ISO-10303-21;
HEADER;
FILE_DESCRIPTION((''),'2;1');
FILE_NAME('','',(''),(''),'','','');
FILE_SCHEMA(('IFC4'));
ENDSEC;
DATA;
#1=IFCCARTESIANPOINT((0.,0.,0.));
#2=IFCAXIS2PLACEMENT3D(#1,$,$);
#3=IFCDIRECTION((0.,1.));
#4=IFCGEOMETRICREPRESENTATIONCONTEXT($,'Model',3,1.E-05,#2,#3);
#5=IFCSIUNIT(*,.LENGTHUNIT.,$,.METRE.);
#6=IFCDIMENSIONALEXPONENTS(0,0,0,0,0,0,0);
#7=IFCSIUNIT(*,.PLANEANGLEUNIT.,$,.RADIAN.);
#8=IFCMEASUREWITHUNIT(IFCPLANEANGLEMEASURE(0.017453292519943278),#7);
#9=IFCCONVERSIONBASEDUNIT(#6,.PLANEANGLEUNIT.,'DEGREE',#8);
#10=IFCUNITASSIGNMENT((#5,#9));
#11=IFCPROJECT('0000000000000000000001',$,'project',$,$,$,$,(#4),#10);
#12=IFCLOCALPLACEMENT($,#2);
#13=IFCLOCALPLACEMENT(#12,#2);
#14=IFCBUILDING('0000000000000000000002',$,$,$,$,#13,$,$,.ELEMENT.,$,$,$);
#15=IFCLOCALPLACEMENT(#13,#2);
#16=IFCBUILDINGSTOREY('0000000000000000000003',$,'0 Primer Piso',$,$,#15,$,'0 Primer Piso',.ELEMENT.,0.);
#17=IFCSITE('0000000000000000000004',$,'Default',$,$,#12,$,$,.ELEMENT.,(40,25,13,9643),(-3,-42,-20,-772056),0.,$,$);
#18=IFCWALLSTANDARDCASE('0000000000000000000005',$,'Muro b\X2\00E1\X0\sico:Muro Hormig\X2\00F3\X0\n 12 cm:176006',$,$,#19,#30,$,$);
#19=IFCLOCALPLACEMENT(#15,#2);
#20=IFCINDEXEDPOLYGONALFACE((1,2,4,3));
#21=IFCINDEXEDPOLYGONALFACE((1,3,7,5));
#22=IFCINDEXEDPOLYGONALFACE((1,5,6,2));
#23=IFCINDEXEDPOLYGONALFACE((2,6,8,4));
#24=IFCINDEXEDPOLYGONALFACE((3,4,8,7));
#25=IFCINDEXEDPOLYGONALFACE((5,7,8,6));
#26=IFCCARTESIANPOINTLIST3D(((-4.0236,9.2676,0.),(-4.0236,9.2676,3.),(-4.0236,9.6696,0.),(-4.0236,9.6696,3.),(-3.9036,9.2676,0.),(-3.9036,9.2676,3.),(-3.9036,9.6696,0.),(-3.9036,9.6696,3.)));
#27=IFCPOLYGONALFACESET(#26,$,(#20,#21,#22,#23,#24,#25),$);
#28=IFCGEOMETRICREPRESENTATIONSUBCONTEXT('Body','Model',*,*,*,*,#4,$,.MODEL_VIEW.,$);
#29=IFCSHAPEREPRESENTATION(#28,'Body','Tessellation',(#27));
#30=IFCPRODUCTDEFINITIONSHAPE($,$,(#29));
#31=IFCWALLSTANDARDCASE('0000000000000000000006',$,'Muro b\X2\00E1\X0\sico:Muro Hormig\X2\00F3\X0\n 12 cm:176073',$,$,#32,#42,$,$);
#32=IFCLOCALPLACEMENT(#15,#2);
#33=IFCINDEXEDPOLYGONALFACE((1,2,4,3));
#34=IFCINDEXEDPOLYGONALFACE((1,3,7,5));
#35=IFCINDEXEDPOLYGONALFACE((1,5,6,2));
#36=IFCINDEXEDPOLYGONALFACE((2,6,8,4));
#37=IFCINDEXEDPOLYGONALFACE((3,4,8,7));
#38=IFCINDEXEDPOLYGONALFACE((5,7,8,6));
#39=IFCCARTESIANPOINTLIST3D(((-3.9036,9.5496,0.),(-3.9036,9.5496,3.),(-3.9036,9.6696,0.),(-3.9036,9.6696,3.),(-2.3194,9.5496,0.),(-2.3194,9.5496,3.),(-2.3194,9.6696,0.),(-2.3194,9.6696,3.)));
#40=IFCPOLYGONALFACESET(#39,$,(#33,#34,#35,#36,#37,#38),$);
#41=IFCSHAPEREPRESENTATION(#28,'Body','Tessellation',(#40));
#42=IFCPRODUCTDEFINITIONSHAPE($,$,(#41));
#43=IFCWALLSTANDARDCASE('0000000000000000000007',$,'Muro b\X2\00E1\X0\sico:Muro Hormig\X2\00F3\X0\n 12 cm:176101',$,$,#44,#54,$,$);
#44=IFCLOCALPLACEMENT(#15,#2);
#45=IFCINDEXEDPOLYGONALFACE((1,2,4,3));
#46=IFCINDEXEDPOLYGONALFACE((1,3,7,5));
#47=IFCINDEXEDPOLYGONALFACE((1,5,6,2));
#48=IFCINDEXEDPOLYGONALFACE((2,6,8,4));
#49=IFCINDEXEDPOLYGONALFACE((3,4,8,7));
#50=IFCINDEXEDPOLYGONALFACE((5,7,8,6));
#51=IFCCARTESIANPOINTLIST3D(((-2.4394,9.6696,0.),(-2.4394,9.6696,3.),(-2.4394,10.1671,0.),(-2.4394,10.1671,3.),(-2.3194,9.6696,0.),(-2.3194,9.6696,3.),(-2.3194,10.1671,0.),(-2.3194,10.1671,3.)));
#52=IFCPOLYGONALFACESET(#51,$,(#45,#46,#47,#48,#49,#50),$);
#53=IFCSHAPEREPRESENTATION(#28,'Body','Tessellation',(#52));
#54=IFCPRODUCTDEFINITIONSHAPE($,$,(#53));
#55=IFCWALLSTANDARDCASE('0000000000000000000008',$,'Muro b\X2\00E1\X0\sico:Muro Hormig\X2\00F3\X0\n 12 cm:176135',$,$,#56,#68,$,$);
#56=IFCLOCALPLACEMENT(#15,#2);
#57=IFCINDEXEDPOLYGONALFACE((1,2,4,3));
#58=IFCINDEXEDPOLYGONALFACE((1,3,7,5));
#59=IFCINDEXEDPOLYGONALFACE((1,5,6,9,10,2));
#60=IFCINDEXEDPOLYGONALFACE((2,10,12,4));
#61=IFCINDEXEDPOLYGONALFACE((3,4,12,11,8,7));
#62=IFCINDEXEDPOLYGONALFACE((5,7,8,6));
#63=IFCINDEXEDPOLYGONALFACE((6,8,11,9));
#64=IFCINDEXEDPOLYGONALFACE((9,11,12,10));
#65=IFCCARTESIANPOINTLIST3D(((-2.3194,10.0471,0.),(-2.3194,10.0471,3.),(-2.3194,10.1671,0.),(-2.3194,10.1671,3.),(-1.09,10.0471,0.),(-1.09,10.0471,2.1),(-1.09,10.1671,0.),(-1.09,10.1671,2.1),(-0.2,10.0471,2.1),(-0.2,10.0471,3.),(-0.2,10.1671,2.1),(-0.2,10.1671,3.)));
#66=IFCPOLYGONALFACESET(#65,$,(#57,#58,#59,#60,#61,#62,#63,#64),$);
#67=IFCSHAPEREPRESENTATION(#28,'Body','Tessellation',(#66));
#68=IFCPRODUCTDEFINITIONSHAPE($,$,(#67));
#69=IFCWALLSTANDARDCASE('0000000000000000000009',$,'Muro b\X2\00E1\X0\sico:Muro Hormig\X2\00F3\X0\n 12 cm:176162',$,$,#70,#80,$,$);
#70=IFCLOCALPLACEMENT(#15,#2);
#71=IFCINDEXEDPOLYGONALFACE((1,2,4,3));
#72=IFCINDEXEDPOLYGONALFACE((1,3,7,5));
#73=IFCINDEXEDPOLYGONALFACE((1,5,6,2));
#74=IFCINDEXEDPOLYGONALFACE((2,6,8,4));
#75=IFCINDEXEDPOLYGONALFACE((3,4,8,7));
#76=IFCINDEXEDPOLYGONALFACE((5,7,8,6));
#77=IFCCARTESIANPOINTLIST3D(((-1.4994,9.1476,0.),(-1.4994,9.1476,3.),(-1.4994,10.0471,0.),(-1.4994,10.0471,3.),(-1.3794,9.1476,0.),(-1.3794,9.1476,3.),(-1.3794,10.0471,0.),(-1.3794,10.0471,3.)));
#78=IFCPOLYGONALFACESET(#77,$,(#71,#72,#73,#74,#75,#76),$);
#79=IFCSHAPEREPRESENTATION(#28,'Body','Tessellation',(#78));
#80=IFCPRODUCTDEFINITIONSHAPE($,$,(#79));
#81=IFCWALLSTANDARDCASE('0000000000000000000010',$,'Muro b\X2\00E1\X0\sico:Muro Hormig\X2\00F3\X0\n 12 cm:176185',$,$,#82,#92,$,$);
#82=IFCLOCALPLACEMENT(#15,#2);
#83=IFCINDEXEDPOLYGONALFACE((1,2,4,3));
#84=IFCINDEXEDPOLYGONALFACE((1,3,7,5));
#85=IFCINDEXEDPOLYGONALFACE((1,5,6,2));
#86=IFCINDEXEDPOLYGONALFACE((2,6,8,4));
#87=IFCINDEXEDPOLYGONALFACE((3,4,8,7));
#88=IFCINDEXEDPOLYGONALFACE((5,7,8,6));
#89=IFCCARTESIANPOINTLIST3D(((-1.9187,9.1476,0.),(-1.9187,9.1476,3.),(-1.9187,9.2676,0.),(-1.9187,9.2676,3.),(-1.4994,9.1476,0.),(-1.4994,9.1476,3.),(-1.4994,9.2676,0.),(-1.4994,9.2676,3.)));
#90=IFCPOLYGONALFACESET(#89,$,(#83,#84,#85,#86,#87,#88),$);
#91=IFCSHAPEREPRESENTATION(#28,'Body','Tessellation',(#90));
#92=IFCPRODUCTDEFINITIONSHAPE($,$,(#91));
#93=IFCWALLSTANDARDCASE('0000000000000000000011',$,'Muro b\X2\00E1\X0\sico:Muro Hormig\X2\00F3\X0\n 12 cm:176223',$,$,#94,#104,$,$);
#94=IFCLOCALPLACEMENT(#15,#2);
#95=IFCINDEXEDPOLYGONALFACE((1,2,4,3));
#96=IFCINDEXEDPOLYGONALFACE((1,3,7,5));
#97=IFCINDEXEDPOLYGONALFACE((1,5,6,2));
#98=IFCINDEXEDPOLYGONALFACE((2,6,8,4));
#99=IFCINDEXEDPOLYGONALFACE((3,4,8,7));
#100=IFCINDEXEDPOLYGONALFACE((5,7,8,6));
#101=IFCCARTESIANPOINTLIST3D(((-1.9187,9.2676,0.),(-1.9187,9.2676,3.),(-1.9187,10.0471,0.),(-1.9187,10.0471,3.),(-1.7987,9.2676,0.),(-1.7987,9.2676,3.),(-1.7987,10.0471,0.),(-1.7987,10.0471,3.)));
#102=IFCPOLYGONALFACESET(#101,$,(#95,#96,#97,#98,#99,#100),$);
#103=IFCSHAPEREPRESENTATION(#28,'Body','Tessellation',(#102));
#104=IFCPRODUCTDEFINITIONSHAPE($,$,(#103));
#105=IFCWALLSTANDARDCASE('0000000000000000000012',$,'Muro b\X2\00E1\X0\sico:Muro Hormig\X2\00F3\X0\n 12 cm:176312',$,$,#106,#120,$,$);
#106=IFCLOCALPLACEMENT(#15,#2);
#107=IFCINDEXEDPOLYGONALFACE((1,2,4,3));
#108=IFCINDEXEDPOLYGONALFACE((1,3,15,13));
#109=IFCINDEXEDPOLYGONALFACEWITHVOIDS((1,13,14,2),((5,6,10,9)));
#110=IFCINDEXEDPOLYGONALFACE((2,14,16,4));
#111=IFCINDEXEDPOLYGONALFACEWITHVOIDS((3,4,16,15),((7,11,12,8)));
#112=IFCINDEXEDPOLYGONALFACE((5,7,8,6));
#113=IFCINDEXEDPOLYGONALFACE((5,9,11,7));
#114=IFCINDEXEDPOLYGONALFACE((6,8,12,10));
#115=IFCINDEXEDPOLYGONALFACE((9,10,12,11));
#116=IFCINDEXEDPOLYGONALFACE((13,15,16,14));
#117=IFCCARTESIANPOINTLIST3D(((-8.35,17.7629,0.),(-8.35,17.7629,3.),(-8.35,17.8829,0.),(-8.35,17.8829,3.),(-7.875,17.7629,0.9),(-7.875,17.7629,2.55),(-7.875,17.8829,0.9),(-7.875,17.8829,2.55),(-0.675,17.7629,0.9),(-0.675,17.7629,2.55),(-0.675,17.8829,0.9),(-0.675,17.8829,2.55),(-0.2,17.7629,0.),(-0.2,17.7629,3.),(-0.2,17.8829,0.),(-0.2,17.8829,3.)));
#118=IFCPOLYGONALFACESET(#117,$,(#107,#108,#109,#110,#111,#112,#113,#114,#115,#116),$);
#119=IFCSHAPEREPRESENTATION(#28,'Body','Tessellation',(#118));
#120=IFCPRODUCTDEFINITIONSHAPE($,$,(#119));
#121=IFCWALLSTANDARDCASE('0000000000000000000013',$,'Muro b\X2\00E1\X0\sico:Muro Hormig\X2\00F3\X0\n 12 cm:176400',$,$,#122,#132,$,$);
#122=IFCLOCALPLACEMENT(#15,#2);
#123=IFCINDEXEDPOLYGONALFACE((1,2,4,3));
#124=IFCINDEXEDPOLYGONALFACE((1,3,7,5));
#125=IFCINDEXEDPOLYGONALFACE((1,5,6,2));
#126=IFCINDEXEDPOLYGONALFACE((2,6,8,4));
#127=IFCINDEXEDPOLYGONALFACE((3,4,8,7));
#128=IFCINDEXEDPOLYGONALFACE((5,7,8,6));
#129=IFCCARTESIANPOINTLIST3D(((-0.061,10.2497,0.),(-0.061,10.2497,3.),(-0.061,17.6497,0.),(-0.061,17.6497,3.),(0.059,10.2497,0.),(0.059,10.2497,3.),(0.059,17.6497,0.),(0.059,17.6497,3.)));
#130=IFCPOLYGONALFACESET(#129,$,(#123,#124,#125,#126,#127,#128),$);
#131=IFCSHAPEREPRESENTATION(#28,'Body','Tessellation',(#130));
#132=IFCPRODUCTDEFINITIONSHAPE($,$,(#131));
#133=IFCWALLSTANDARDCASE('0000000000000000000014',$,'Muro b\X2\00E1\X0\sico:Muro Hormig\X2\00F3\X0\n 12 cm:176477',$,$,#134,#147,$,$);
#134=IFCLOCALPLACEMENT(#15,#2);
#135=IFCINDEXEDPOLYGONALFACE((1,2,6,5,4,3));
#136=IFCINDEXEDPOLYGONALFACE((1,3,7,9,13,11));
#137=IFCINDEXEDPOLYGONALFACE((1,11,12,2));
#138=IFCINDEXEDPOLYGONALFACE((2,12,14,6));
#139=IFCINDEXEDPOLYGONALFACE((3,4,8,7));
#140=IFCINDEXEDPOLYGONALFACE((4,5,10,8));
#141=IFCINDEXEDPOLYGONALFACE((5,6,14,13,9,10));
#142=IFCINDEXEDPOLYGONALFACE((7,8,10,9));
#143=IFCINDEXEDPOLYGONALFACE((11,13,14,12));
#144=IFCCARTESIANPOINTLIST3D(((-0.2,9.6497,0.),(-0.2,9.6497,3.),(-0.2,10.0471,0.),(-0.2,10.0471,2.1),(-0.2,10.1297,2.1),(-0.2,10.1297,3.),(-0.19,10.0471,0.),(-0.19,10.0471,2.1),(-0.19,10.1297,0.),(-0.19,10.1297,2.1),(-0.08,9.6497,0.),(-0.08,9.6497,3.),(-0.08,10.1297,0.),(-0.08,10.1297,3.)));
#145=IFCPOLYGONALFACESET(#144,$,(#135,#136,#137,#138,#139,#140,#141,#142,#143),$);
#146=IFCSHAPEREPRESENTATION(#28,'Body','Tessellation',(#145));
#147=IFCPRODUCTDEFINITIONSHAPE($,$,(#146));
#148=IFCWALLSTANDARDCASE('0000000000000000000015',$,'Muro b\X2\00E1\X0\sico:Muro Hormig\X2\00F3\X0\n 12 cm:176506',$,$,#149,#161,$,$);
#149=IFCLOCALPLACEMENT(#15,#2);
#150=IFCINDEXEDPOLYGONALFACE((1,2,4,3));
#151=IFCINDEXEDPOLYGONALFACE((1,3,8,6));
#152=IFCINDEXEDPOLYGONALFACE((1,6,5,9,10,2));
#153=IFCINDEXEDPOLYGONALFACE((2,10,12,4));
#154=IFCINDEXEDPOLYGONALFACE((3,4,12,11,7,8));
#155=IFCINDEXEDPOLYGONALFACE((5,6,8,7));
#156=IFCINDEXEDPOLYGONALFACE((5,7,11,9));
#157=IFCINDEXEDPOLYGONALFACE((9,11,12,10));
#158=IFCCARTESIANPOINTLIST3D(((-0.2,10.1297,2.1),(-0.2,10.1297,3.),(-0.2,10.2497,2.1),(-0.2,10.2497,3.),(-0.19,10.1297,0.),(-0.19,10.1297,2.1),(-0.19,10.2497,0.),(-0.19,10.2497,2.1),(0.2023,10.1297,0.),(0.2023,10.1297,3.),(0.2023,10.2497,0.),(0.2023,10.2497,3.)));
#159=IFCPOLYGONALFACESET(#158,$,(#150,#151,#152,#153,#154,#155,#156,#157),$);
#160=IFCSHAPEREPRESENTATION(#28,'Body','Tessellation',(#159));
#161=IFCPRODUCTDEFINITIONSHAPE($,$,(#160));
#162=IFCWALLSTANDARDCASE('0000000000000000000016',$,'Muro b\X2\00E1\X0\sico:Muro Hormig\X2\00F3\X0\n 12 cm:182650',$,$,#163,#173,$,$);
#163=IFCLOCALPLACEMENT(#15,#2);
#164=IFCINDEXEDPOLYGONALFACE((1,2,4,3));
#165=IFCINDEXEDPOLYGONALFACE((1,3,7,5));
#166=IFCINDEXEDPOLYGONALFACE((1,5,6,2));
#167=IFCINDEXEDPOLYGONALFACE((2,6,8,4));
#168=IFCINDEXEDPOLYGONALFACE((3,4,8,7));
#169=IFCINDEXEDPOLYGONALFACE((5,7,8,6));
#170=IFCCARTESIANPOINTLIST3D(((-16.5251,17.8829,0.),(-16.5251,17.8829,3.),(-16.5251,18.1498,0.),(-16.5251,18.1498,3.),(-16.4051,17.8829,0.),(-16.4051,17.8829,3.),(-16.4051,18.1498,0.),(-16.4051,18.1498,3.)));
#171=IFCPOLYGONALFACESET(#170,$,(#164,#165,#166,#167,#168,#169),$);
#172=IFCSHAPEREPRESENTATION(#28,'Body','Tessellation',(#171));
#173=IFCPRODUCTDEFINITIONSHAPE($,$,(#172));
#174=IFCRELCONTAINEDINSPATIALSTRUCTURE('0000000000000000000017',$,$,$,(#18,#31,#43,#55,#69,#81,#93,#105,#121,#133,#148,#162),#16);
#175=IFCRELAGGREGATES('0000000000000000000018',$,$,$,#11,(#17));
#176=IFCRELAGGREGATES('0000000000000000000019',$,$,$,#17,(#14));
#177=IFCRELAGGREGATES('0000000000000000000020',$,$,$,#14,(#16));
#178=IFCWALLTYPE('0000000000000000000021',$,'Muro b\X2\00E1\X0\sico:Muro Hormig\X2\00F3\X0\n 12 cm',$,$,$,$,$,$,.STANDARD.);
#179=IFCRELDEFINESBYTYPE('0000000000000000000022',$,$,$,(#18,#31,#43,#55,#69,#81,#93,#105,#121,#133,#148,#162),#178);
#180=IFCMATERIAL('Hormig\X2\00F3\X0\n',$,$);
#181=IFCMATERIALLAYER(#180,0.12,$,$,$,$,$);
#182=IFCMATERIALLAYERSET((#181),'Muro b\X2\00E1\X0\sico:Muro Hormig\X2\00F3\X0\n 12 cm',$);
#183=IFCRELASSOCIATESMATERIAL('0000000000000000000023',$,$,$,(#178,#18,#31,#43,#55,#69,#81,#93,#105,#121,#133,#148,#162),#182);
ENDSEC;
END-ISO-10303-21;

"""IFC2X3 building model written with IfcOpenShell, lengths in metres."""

from ifc_helpers import new_model, entity, si_unit, converted_unit, direction, frame, frame_2d, origin, place, context, subcontext, project, spatial, rectangle, extrude, material, layer, layer_set, layer_usage, type_object, element, save


model = new_model("IFC2X3")

# Units and contexts
model_context = context("Model", 3, precision=1e-05, world=origin(), true_north=direction((0.0, 1.0)))
body_context = subcontext(model_context, "Body", "Model", "MODEL_VIEW")
ifc_project = project(units=[si_unit("LENGTHUNIT", "METRE"), converted_unit("PLANEANGLEUNIT", "DEGREE", entity("IfcPlaneAngleMeasure", 0.017453292519943278), si_unit("PLANEANGLEUNIT", "RADIAN"), dimensions=[0, 0, 0, 0, 0, 0, 0])], contexts=[model_context])

# Site, building, storey
site_placement = place(None, origin())
site = spatial("IfcSite", under=ifc_project, at=site_placement, Name="Default", CompositionType="ELEMENT", RefLatitude=(40, 25, 13, 9643), RefLongitude=(-3, -42, -20, -772056), RefElevation=0.0)
building_placement = place(site_placement, origin())
building = spatial("IfcBuilding", under=site, at=building_placement, CompositionType="ELEMENT")
storey_placement = place(building_placement, origin())
storey = spatial("IfcBuildingStorey", under=building, at=storey_placement, Name="0 Primer Piso", LongName="0 Primer Piso", CompositionType="ELEMENT", Elevation=0.0)

# Shared definitions
ifc_material = material(Name="Hormigón")
ifc_layer = layer(ifc_material, 0.12)
ifc_layer_set = layer_set([ifc_layer], Name="Muro básico:Muro Hormigón 12 cm")
wall_type = type_object("IfcWallType", Name="Muro básico:Muro Hormigón 12 cm", PredefinedType="STANDARD", material=ifc_layer_set)

# Walls
ifc_layer_usage_1 = layer_usage(ifc_layer_set, "AXIS2", "NEGATIVE", 0.06)
wall_1_placement = place(storey_placement, frame((-3.9636, 9.2676, 0.0), z_axis=(0.0, 0.0, 1.0), x_axis=(0.0, 1.0, 0.0)))
element("IfcWallStandardCase", 1, at=wall_1_placement, inside=storey, type_object=wall_type, material=ifc_layer_usage_1, Name="Muro básico:Muro Hormigón 12 cm:176006", context=body_context, shape_type="SweptSolid", body=[
    extrude(rectangle(XDim=0.402, YDim=0.12, at=frame_2d((0.201, 0.0), x_axis=(-1.0, 0.0))), origin(), (0.0, 0.0, 1.0), 3.0),
])
ifc_layer_usage_2 = layer_usage(ifc_layer_set, "AXIS2", "NEGATIVE", 0.06)
wall_2_placement = place(storey_placement, frame((-3.9036, 9.6096, 0.0)))
element("IfcWallStandardCase", 2, at=wall_2_placement, inside=storey, type_object=wall_type, material=ifc_layer_usage_2, Name="Muro básico:Muro Hormigón 12 cm:176073", context=body_context, shape_type="SweptSolid", body=[
    extrude(rectangle(XDim=1.5842, YDim=0.12, at=frame_2d((0.7921, 0.0), x_axis=(-1.0, 0.0))), origin(), (0.0, 0.0, 1.0), 3.0),
])
ifc_layer_usage_3 = layer_usage(ifc_layer_set, "AXIS2", "NEGATIVE", 0.06)
wall_3_placement = place(storey_placement, frame((-2.3794, 9.6696, 0.0), z_axis=(0.0, 0.0, 1.0), x_axis=(0.0, 1.0, 0.0)))
element("IfcWallStandardCase", 3, at=wall_3_placement, inside=storey, type_object=wall_type, material=ifc_layer_usage_3, Name="Muro básico:Muro Hormigón 12 cm:176101", context=body_context, shape_type="SweptSolid", body=[
    extrude(rectangle(XDim=0.4975, YDim=0.12, at=frame_2d((0.2487, 0.0), x_axis=(-1.0, 0.0))), origin(), (0.0, 0.0, 1.0), 3.0),
])

# Wall, opening
ifc_layer_usage_4 = layer_usage(ifc_layer_set, "AXIS2", "NEGATIVE", 0.06)
wall_4_placement = place(storey_placement, frame((-2.3194, 10.1071, 0.0)))
wall_4 = element("IfcWallStandardCase", 4, at=wall_4_placement, inside=storey, type_object=wall_type, material=ifc_layer_usage_4, Name="Muro básico:Muro Hormigón 12 cm:176135", context=body_context, shape_type="SweptSolid", body=[
    extrude(rectangle(XDim=2.1194, YDim=0.12, at=frame_2d((1.0597, 0.0), x_axis=(-1.0, 0.0))), origin(), (0.0, 0.0, 1.0), 3.0),
])
opening_1_placement = place(wall_4_placement, frame((2.1294, 0.06, 0.0)))
element("IfcOpeningElement", 5, at=opening_1_placement, cuts=wall_4, ObjectType="Opening", context=body_context, shape_type="SweptSolid", body=[
    extrude(rectangle(XDim=2.1, YDim=0.9, at=frame_2d((1.05, 0.45), x_axis=(1.0, 0.0))), frame((0.0, 0.0, 0.0), z_axis=(0.0, -1.0, 0.0), x_axis=(0.0, 0.0, 1.0)), (0.0, 0.0, 1.0), 0.12),
])

# Walls
ifc_layer_usage_5 = layer_usage(ifc_layer_set, "AXIS2", "NEGATIVE", 0.06)
wall_5_placement = place(storey_placement, frame((-1.4394, 10.0471, 0.0), z_axis=(0.0, 0.0, 1.0), x_axis=(0.0, -1.0, 0.0)))
element("IfcWallStandardCase", 6, at=wall_5_placement, inside=storey, type_object=wall_type, material=ifc_layer_usage_5, Name="Muro básico:Muro Hormigón 12 cm:176162", context=body_context, shape_type="SweptSolid", body=[
    extrude(rectangle(XDim=0.8995, YDim=0.12, at=frame_2d((0.4497, 0.0), x_axis=(-1.0, 0.0))), origin(), (0.0, 0.0, 1.0), 3.0),
])
ifc_layer_usage_6 = layer_usage(ifc_layer_set, "AXIS2", "NEGATIVE", 0.06)
wall_6_placement = place(storey_placement, frame((-1.4994, 9.2076, 0.0), z_axis=(0.0, 0.0, 1.0), x_axis=(-1.0, 0.0, 0.0)))
element("IfcWallStandardCase", 7, at=wall_6_placement, inside=storey, type_object=wall_type, material=ifc_layer_usage_6, Name="Muro básico:Muro Hormigón 12 cm:176185", context=body_context, shape_type="SweptSolid", body=[
    extrude(rectangle(XDim=0.4193, YDim=0.12, at=frame_2d((0.2096, 0.0), x_axis=(-1.0, 0.0))), origin(), (0.0, 0.0, 1.0), 3.0),
])
ifc_layer_usage_7 = layer_usage(ifc_layer_set, "AXIS2", "NEGATIVE", 0.06)
wall_7_placement = place(storey_placement, frame((-1.8587, 9.2676, 0.0), z_axis=(0.0, 0.0, 1.0), x_axis=(0.0, 1.0, 0.0)))
element("IfcWallStandardCase", 8, at=wall_7_placement, inside=storey, type_object=wall_type, material=ifc_layer_usage_7, Name="Muro básico:Muro Hormigón 12 cm:176223", context=body_context, shape_type="SweptSolid", body=[
    extrude(rectangle(XDim=0.7795, YDim=0.12, at=frame_2d((0.3897, 0.0), x_axis=(-1.0, 0.0))), origin(), (0.0, 0.0, 1.0), 3.0),
])

# Wall, opening
ifc_layer_usage_8 = layer_usage(ifc_layer_set, "AXIS2", "NEGATIVE", 0.06)
wall_8_placement = place(storey_placement, frame((-8.35, 17.8229, 0.0)))
wall_8 = element("IfcWallStandardCase", 9, at=wall_8_placement, inside=storey, type_object=wall_type, material=ifc_layer_usage_8, Name="Muro básico:Muro Hormigón 12 cm:176312", context=body_context, shape_type="SweptSolid", body=[
    extrude(rectangle(XDim=8.15, YDim=0.12, at=frame_2d((4.075, 0.0), x_axis=(-1.0, 0.0))), origin(), (0.0, 0.0, 1.0), 3.0),
])
opening_2_placement = place(wall_8_placement, frame((7.675, 0.06, 0.9)))
element("IfcOpeningElement", 10, at=opening_2_placement, cuts=wall_8, ObjectType="Opening", context=body_context, shape_type="SweptSolid", body=[
    extrude(rectangle(XDim=1.65, YDim=7.2, at=frame_2d((0.825, 3.6), x_axis=(1.0, 0.0))), frame((0.0, 0.0, 0.0), z_axis=(0.0, -1.0, 0.0), x_axis=(0.0, 0.0, 1.0)), (0.0, 0.0, 1.0), 0.12),
])

# Wall
ifc_layer_usage_9 = layer_usage(ifc_layer_set, "AXIS2", "NEGATIVE", 0.06)
wall_9_placement = place(storey_placement, frame((-0.001, 17.6497, 0.0), z_axis=(0.0, 0.0, 1.0), x_axis=(0.0, -1.0, 0.0)))
element("IfcWallStandardCase", 11, at=wall_9_placement, inside=storey, type_object=wall_type, material=ifc_layer_usage_9, Name="Muro básico:Muro Hormigón 12 cm:176400", context=body_context, shape_type="SweptSolid", body=[
    extrude(rectangle(XDim=7.4, YDim=0.12, at=frame_2d((3.7, 0.0), x_axis=(-1.0, 0.0))), origin(), (0.0, 0.0, 1.0), 3.0),
])

# Walls, openings
ifc_layer_usage_10 = layer_usage(ifc_layer_set, "AXIS2", "NEGATIVE", 0.06)
wall_10_placement = place(storey_placement, frame((-0.14, 9.6497, 0.0), z_axis=(0.0, 0.0, 1.0), x_axis=(0.0, 1.0, 0.0)))
wall_10 = element("IfcWallStandardCase", 12, at=wall_10_placement, inside=storey, type_object=wall_type, material=ifc_layer_usage_10, Name="Muro básico:Muro Hormigón 12 cm:176477", context=body_context, shape_type="SweptSolid", body=[
    extrude(rectangle(XDim=0.48, YDim=0.12, at=frame_2d((0.24, 0.0), x_axis=(-1.0, 0.0))), origin(), (0.0, 0.0, 1.0), 3.0),
])
opening_3_placement = place(wall_10_placement, origin())
element("IfcOpeningElement", 13, at=opening_3_placement, cuts=wall_10, ObjectType="Opening", context=body_context, shape_type="SweptSolid", body=[
    extrude(rectangle(XDim=2.1, YDim=0.12, at=frame_2d((0.0, 0.0), x_axis=(0.0, 1.0))), frame((0.4574, 0.05, 1.05), z_axis=(0.0, 1.0, 0.0), x_axis=(1.0, 0.0, 0.0)), (0.0, 0.0, 1.0), 0.9),
])
ifc_layer_usage_11 = layer_usage(ifc_layer_set, "AXIS2", "NEGATIVE", 0.06)
wall_11_placement = place(storey_placement, frame((-0.2, 10.1897, 0.0)))
wall_11 = element("IfcWallStandardCase", 14, at=wall_11_placement, inside=storey, type_object=wall_type, material=ifc_layer_usage_11, Name="Muro básico:Muro Hormigón 12 cm:176506", context=body_context, shape_type="SweptSolid", body=[
    extrude(rectangle(XDim=0.4023, YDim=0.12, at=frame_2d((0.2012, 0.0), x_axis=(-1.0, 0.0))), origin(), (0.0, 0.0, 1.0), 3.0),
])
opening_4_placement = place(wall_11_placement, origin())
element("IfcOpeningElement", 15, at=opening_4_placement, cuts=wall_11, ObjectType="Opening", context=body_context, shape_type="SweptSolid", body=[
    extrude(rectangle(XDim=2.1, YDim=0.9, at=frame_2d((0.0, 0.0), x_axis=(0.0, 1.0))), frame((-0.44, -1.5466, 1.05), z_axis=(0.0, 1.0, 0.0), x_axis=(-1.0, 0.0, 0.0)), (0.0, 0.0, 1.0), 3.048),
])

# Wall
ifc_layer_usage_12 = layer_usage(ifc_layer_set, "AXIS2", "NEGATIVE", 0.06)
wall_12_placement = place(storey_placement, frame((-16.4651, 17.8829, 0.0), z_axis=(0.0, 0.0, 1.0), x_axis=(0.0, 1.0, 0.0)))
element("IfcWallStandardCase", 16, at=wall_12_placement, inside=storey, type_object=wall_type, material=ifc_layer_usage_12, Name="Muro básico:Muro Hormigón 12 cm:182650", context=body_context, shape_type="SweptSolid", body=[
    extrude(rectangle(XDim=0.2668, YDim=0.12, at=frame_2d((0.1334, 0.0), x_axis=(-1.0, 0.0))), origin(), (0.0, 0.0, 1.0), 3.0),
])

save(model, "model.ifc")
